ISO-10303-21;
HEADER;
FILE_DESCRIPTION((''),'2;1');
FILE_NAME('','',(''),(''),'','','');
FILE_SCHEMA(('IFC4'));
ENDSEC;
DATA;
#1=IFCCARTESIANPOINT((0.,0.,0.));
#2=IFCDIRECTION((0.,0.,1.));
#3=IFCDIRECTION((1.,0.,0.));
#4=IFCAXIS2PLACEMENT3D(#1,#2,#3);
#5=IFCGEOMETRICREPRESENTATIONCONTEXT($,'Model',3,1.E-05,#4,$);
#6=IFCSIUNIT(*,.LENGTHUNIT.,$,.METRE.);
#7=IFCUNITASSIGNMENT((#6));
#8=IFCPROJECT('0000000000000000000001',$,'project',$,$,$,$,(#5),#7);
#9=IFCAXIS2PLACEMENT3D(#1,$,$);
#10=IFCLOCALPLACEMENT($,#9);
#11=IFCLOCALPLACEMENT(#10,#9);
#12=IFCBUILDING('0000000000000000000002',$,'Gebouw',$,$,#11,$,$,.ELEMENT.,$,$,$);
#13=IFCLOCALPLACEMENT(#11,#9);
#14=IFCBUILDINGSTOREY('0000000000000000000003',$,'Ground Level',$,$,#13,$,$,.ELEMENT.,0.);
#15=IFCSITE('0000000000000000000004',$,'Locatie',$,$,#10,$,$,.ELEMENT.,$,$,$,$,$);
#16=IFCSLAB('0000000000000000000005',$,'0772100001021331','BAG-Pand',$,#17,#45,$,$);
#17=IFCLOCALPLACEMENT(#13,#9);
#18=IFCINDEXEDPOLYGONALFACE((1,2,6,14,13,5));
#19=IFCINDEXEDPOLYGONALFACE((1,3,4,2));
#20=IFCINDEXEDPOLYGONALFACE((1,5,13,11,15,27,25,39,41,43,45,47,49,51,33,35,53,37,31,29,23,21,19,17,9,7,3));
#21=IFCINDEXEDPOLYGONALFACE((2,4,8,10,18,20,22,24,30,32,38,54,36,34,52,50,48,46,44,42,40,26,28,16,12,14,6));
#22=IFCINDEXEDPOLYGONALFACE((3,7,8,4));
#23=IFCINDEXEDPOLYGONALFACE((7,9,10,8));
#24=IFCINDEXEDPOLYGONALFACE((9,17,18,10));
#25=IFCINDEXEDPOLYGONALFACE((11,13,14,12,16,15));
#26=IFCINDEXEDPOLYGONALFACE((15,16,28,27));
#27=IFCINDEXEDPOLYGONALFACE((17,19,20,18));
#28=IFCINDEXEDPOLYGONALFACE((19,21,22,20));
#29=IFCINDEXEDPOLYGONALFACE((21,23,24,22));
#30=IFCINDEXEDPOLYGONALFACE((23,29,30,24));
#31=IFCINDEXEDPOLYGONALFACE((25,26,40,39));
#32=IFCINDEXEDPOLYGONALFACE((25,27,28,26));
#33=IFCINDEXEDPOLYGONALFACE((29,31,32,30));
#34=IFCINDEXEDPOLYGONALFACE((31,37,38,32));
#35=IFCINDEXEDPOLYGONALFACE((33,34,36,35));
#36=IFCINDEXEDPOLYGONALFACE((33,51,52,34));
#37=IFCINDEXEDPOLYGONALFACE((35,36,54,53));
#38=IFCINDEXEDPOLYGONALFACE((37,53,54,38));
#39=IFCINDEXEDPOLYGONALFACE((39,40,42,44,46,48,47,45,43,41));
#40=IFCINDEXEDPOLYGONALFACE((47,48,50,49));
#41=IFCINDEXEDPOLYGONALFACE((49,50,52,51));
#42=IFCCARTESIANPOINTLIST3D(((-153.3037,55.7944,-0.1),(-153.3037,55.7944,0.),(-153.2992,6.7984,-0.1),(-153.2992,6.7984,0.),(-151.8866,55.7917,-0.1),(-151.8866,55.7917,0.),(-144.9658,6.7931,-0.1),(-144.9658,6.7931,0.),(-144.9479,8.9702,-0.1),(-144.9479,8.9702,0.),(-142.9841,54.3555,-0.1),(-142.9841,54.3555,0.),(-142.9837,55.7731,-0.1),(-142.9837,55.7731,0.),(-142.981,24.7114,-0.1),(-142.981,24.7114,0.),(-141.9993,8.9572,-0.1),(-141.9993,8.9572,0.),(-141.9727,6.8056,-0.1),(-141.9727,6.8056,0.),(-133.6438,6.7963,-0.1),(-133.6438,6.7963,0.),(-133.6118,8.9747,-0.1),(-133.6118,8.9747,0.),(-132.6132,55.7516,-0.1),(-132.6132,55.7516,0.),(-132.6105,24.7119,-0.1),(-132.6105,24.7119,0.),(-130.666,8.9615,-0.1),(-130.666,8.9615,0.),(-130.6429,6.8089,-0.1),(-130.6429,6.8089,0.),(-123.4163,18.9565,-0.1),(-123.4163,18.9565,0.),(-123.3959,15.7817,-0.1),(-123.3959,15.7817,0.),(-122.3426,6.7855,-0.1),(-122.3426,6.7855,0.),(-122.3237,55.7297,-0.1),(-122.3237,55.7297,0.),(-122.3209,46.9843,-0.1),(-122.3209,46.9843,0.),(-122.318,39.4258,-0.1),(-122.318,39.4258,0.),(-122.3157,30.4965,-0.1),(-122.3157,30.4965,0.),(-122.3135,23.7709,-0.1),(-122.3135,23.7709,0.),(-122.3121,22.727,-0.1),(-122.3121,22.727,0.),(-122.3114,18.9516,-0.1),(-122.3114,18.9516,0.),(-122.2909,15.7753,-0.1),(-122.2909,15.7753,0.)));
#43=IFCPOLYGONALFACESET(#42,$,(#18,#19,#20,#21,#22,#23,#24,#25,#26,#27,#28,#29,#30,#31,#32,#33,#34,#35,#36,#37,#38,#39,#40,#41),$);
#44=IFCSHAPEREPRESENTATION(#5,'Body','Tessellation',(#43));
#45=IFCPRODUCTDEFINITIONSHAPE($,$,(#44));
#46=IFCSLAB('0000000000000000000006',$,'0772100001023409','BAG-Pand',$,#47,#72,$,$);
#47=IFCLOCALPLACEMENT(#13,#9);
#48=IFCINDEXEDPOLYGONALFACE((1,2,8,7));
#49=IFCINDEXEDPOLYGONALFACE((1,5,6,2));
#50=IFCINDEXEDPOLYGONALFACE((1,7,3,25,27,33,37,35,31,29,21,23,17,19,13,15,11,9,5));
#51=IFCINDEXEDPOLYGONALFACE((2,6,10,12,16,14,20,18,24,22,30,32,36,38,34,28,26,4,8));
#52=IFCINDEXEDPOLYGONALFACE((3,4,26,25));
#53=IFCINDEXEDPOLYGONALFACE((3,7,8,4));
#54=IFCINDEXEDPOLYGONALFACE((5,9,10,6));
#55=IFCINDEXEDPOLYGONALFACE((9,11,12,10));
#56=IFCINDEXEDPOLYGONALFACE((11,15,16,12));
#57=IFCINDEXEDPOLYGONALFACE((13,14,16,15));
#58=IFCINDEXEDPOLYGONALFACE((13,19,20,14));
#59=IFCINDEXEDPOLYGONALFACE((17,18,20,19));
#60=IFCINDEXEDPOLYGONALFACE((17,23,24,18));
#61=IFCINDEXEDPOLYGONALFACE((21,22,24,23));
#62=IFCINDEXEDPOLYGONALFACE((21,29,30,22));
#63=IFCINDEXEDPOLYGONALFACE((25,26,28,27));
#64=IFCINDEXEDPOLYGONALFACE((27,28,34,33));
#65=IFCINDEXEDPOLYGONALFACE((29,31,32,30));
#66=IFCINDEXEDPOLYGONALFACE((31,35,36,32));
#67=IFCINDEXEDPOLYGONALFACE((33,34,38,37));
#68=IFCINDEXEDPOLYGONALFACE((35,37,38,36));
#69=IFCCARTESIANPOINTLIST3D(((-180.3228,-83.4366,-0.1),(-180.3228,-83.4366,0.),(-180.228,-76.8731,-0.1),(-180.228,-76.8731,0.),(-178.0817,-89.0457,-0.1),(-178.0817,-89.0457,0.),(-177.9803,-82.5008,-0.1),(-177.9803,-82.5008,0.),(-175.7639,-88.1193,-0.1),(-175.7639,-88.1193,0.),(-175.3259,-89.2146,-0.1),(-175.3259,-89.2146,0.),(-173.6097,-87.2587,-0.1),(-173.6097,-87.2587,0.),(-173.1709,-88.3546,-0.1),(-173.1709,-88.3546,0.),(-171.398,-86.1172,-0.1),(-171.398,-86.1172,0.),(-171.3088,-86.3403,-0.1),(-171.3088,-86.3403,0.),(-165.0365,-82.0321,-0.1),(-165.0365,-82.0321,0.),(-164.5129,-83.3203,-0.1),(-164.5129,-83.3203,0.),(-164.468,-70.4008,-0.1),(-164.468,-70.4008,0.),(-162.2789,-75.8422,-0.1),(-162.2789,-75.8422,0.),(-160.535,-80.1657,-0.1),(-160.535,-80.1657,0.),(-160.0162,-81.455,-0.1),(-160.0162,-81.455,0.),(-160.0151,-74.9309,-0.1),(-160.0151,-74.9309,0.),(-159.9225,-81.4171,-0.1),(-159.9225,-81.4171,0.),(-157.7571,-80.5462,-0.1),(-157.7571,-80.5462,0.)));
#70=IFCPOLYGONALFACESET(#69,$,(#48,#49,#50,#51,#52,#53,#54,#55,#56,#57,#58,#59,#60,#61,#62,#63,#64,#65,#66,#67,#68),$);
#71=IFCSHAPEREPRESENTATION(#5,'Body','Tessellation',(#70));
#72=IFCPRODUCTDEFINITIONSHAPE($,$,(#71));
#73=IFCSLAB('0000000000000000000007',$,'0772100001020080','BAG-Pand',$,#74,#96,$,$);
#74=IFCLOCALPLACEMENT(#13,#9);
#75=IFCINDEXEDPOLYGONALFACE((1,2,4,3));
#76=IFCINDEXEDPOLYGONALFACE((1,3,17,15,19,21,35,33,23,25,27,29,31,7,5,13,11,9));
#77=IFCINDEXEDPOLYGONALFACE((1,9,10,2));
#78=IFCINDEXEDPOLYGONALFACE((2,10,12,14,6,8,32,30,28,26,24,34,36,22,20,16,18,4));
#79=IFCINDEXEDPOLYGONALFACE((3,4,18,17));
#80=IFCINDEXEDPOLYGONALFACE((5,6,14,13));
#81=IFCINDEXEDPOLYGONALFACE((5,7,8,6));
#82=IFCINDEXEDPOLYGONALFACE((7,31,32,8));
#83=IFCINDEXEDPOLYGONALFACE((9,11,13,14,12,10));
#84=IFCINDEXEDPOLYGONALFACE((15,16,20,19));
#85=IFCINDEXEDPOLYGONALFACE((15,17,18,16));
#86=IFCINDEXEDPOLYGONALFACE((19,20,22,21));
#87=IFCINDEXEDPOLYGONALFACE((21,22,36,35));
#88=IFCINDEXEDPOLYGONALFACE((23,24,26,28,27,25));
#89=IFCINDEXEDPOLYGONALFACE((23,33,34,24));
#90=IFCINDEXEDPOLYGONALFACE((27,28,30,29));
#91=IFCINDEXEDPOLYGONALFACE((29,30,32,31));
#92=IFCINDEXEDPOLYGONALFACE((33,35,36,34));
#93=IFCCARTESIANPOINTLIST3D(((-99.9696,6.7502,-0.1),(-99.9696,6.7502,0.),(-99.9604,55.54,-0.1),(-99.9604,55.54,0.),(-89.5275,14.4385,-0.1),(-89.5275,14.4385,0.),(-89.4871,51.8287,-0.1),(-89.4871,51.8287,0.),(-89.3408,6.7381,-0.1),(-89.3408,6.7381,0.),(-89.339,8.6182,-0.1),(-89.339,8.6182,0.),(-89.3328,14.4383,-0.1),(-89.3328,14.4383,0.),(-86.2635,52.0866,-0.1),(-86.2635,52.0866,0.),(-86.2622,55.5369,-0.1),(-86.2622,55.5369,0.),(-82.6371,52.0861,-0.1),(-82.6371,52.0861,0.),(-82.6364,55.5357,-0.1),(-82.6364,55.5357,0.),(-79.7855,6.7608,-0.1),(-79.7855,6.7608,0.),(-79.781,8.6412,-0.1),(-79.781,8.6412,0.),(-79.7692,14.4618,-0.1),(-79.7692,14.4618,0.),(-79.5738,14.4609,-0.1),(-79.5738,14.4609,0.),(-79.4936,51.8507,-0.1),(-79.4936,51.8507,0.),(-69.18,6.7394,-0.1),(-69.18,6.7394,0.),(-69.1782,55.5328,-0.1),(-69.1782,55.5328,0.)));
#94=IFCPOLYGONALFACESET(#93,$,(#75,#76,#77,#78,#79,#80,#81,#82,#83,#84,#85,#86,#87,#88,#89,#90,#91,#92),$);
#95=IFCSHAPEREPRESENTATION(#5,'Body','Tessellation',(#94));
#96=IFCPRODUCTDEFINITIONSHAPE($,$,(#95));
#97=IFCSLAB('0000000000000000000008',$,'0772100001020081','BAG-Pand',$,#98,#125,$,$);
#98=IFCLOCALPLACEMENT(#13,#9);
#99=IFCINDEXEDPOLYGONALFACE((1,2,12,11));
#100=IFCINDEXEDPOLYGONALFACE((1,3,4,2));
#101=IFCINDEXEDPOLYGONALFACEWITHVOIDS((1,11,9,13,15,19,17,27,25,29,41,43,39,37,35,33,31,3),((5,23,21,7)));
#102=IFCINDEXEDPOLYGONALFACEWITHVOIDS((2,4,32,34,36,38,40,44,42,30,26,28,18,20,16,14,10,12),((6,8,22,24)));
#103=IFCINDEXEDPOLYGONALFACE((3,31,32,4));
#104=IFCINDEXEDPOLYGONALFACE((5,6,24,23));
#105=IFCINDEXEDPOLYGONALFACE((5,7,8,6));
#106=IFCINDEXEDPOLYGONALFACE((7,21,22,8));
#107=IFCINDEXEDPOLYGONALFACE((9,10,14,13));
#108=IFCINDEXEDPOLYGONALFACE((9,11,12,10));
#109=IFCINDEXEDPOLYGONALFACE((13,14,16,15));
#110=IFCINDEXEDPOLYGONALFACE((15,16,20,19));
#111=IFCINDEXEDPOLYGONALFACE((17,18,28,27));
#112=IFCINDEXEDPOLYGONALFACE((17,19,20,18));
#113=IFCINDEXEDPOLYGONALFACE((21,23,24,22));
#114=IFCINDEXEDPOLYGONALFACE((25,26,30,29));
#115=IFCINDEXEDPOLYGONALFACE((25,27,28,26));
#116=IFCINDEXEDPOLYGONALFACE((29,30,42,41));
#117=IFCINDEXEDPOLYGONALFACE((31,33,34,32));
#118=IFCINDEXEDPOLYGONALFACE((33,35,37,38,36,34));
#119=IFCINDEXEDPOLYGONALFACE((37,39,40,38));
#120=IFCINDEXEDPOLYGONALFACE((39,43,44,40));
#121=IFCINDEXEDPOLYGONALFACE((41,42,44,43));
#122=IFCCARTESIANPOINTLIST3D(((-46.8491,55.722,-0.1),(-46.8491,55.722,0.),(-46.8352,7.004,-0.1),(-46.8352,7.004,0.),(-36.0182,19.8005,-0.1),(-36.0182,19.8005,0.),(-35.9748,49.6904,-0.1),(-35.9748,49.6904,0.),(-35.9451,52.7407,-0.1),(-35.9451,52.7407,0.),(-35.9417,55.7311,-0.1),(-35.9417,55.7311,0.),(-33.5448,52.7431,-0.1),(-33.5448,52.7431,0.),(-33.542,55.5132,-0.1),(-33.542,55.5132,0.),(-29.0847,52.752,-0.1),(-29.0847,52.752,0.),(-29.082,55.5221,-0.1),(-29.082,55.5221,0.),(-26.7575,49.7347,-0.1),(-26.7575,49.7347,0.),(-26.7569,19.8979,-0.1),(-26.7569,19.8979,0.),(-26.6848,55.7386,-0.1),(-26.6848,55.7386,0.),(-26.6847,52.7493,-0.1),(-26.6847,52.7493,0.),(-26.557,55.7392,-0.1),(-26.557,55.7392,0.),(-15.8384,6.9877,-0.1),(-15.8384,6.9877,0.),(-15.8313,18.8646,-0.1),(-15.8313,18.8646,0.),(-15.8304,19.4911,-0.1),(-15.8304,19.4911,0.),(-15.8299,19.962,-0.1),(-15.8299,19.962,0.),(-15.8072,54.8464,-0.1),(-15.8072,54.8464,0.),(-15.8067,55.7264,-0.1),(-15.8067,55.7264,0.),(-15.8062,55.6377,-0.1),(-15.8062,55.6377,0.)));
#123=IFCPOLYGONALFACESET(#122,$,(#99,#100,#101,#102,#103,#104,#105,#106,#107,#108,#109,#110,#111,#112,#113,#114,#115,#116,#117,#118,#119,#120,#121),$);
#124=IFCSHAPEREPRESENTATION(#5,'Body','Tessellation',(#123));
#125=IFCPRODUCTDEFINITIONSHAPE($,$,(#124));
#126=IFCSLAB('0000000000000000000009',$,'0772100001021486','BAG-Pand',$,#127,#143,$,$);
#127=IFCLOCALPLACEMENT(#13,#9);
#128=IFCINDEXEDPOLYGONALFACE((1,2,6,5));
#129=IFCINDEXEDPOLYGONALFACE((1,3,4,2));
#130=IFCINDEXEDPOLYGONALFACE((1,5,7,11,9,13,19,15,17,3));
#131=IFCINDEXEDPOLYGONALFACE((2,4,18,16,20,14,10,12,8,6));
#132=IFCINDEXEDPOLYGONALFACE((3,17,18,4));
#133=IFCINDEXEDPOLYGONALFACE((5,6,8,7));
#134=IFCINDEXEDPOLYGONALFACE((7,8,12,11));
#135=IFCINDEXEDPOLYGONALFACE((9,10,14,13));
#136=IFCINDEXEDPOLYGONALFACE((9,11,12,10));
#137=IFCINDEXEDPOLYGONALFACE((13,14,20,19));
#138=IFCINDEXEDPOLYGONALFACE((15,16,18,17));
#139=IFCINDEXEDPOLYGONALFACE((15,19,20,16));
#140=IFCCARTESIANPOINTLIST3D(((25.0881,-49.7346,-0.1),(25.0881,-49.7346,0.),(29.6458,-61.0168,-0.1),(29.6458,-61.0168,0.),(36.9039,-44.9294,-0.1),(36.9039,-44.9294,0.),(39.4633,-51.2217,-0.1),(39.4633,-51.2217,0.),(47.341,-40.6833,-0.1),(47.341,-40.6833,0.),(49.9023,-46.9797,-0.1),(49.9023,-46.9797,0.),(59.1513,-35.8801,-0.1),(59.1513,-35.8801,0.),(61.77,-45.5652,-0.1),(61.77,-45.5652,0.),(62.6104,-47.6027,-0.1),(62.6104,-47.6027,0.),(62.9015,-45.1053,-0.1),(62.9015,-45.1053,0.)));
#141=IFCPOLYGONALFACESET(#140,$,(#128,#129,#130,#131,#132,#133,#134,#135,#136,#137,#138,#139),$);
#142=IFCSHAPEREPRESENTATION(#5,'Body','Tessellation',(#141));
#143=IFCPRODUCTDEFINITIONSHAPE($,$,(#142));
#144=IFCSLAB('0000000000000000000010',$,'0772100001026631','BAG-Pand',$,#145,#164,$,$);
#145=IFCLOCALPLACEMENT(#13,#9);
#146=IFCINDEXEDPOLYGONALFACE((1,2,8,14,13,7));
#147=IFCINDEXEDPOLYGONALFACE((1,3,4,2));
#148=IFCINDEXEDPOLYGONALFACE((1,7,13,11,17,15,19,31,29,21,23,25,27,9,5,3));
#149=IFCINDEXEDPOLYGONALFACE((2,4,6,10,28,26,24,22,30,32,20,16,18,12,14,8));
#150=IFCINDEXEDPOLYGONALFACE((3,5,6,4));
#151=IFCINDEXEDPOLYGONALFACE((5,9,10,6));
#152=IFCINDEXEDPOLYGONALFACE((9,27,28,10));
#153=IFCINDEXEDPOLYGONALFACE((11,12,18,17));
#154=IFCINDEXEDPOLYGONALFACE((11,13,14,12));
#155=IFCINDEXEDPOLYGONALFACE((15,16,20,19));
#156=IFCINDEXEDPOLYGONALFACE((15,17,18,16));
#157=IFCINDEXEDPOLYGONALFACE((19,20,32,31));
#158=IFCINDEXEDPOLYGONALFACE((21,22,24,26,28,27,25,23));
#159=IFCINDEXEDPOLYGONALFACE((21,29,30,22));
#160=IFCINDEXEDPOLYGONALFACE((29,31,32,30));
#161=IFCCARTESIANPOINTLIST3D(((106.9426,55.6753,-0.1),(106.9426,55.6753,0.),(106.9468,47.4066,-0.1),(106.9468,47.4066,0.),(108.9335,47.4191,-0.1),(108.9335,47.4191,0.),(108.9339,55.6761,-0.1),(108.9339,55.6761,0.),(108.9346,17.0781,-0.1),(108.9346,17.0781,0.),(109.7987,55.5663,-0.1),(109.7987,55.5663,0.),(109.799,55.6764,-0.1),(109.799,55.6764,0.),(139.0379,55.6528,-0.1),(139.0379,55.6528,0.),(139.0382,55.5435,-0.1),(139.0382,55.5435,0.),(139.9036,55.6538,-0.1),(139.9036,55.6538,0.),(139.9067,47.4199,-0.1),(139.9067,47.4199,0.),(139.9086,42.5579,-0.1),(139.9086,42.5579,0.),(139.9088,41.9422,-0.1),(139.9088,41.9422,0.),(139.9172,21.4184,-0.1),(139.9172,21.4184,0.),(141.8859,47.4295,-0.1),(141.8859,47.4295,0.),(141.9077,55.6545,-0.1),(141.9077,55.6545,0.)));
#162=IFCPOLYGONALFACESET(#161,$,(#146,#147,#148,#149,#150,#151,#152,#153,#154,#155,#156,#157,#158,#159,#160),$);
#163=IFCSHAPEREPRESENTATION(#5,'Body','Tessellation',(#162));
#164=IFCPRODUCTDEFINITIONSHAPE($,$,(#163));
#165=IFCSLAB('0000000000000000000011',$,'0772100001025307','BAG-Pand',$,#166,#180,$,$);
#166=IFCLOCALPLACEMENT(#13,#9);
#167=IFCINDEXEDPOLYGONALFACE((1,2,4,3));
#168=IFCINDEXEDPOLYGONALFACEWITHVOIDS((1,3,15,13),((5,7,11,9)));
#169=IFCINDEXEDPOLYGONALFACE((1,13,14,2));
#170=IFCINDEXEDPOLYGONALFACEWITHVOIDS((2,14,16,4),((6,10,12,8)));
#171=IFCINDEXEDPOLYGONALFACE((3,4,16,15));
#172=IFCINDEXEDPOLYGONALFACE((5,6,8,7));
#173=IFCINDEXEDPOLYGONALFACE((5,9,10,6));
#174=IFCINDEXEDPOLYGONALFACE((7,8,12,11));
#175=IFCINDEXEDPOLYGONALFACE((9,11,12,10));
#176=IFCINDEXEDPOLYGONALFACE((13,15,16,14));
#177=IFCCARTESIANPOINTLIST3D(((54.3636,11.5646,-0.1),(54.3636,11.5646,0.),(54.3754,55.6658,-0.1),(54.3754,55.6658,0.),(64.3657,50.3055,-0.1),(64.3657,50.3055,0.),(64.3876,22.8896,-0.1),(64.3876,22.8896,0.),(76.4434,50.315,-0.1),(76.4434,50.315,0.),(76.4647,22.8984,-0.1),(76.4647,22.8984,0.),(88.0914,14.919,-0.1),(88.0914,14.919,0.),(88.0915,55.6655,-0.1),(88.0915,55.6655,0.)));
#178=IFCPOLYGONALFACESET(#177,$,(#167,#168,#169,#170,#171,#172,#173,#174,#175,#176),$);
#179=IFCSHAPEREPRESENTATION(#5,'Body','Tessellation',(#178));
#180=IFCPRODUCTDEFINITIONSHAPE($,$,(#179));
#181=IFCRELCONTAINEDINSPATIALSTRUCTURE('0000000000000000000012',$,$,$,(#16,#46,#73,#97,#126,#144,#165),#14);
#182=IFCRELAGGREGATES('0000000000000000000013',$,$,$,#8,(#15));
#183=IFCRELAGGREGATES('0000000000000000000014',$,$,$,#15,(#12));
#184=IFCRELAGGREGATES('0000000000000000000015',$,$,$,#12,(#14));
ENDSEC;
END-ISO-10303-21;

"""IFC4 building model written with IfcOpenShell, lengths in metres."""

from ifc_helpers import new_model, si_unit, frame, origin, origin_with_axes, place, context, project, spatial, polyline, outline, extrude, element, save


model = new_model("IFC4")

# Units and contexts
model_context = context("Model", 3, precision=1e-05, world=origin_with_axes())
ifc_project = project(units=[si_unit("LENGTHUNIT", "METRE")], contexts=[model_context])

# Site, building, storey
site_placement = place(None, origin())
site = spatial("IfcSite", under=ifc_project, at=site_placement, Name="Locatie", CompositionType="ELEMENT")
building_placement = place(site_placement, origin())
building = spatial("IfcBuilding", under=site, at=building_placement, Name="Gebouw", CompositionType="ELEMENT")
storey_placement = place(building_placement, origin())
storey = spatial("IfcBuildingStorey", under=building, at=storey_placement, Name="Ground Level", CompositionType="ELEMENT", Elevation=0.0)

# Slabs
slab_1_placement = place(storey_placement, origin())
element("IfcSlab", 1, at=slab_1_placement, inside=storey, Name="0772100001021331", Description="BAG-Pand", context=model_context, shape_type="SweptSolid", body=[
    extrude(outline(polyline([(-153.3037, 55.7944), (-151.8866, 55.7917), (-142.9837, 55.7731), (-142.9841, 54.3555), (-142.981, 24.7114), (-132.6105, 24.7119), (-132.6132, 55.7516), (-122.3237, 55.7297), (-122.3209, 46.9843), (-122.318, 39.4258), (-122.3157, 30.4965), (-122.3135, 23.7709), (-122.3121, 22.727), (-122.3114, 18.9516), (-123.4163, 18.9565), (-123.3959, 15.7817), (-122.2909, 15.7753), (-122.3426, 6.7855), (-130.6429, 6.8089), (-130.666, 8.9615), (-133.6118, 8.9747), (-133.6438, 6.7963), (-141.9727, 6.8056), (-141.9993, 8.9572), (-144.9479, 8.9702), (-144.9658, 6.7931), (-153.2992, 6.7984), (-153.3037, 55.7944)])), frame((0.0, 0.0, -0.1), z_axis=(0.0, 0.0, 1.0), x_axis=(1.0, 0.0, 0.0)), (0.0, 0.0, 1.0), 0.1),
])
slab_2_placement = place(storey_placement, origin())
element("IfcSlab", 2, at=slab_2_placement, inside=storey, Name="0772100001023409", Description="BAG-Pand", context=model_context, shape_type="SweptSolid", body=[
    extrude(outline(polyline([(-180.3228, -83.4366), (-177.9803, -82.5008), (-180.228, -76.8731), (-164.468, -70.4008), (-162.2789, -75.8422), (-160.0151, -74.9309), (-157.7571, -80.5462), (-159.9225, -81.4171), (-160.0162, -81.455), (-160.535, -80.1657), (-165.0365, -82.0321), (-164.5129, -83.3203), (-171.398, -86.1172), (-171.3088, -86.3403), (-173.6097, -87.2587), (-173.1709, -88.3546), (-175.3259, -89.2146), (-175.7639, -88.1193), (-178.0817, -89.0457), (-180.3228, -83.4366)])), frame((0.0, 0.0, -0.1), z_axis=(0.0, 0.0, 1.0), x_axis=(1.0, 0.0, 0.0)), (0.0, 0.0, 1.0), 0.1),
])
slab_3_placement = place(storey_placement, origin())
element("IfcSlab", 3, at=slab_3_placement, inside=storey, Name="0772100001020080", Description="BAG-Pand", context=model_context, shape_type="SweptSolid", body=[
    extrude(outline(polyline([(-82.6364, 55.5357), (-69.1782, 55.5328), (-69.18, 6.7394), (-79.7855, 6.7608), (-79.781, 8.6412), (-79.7692, 14.4618), (-79.5738, 14.4609), (-79.4936, 51.8507), (-89.4871, 51.8287), (-89.5275, 14.4385), (-89.3328, 14.4383), (-89.339, 8.6182), (-89.3408, 6.7381), (-99.9696, 6.7502), (-99.9604, 55.54), (-86.2622, 55.5369), (-86.2635, 52.0866), (-82.6371, 52.0861), (-82.6364, 55.5357)])), frame((0.0, 0.0, -0.1), z_axis=(0.0, 0.0, 1.0), x_axis=(1.0, 0.0, 0.0)), (0.0, 0.0, 1.0), 0.1),
])
slab_4_placement = place(storey_placement, origin())
element("IfcSlab", 4, at=slab_4_placement, inside=storey, Name="0772100001020081", Description="BAG-Pand", context=model_context, shape_type="SweptSolid", body=[
    extrude(outline(polyline([(-46.8491, 55.722), (-35.9417, 55.7311), (-35.9451, 52.7407), (-33.5448, 52.7431), (-33.542, 55.5132), (-29.082, 55.5221), (-29.0847, 52.752), (-26.6847, 52.7493), (-26.6848, 55.7386), (-26.557, 55.7392), (-15.8067, 55.7264), (-15.8062, 55.6377), (-15.8072, 54.8464), (-15.8299, 19.962), (-15.8304, 19.4911), (-15.8313, 18.8646), (-15.8384, 6.9877), (-46.8352, 7.004), (-46.8491, 55.722)]), holes=[polyline([(-26.7569, 19.8979), (-26.7575, 49.7347), (-35.9748, 49.6904), (-36.0182, 19.8005), (-26.7569, 19.8979)])]), frame((0.0, 0.0, -0.1), z_axis=(0.0, 0.0, 1.0), x_axis=(1.0, 0.0, 0.0)), (0.0, 0.0, 1.0), 0.1),
])
slab_5_placement = place(storey_placement, origin())
element("IfcSlab", 5, at=slab_5_placement, inside=storey, Name="0772100001021486", Description="BAG-Pand", context=model_context, shape_type="SweptSolid", body=[
    extrude(outline(polyline([(25.0881, -49.7346), (36.9039, -44.9294), (39.4633, -51.2217), (49.9023, -46.9797), (47.341, -40.6833), (59.1513, -35.8801), (62.9015, -45.1053), (61.77, -45.5652), (62.6104, -47.6027), (29.6458, -61.0168), (25.0881, -49.7346)])), frame((0.0, 0.0, -0.1), z_axis=(0.0, 0.0, 1.0), x_axis=(1.0, 0.0, 0.0)), (0.0, 0.0, 1.0), 0.1),
])
slab_6_placement = place(storey_placement, origin())
element("IfcSlab", 6, at=slab_6_placement, inside=storey, Name="0772100001026631", Description="BAG-Pand", context=model_context, shape_type="SweptSolid", body=[
    extrude(outline(polyline([(108.9335, 47.4191), (106.9468, 47.4066), (106.9426, 55.6753), (108.9339, 55.6761), (109.799, 55.6764), (109.7987, 55.5663), (139.0382, 55.5435), (139.0379, 55.6528), (139.9036, 55.6538), (141.9077, 55.6545), (141.8859, 47.4295), (139.9067, 47.4199), (139.9086, 42.5579), (139.9088, 41.9422), (139.9172, 21.4184), (108.9346, 17.0781), (108.9335, 47.4191)])), frame((0.0, 0.0, -0.1), z_axis=(0.0, 0.0, 1.0), x_axis=(1.0, 0.0, 0.0)), (0.0, 0.0, 1.0), 0.1),
])
slab_7_placement = place(storey_placement, origin())
element("IfcSlab", 7, at=slab_7_placement, inside=storey, Name="0772100001025307", Description="BAG-Pand", context=model_context, shape_type="SweptSolid", body=[
    extrude(outline(polyline([(54.3754, 55.6658), (88.0915, 55.6655), (88.0914, 14.919), (54.3636, 11.5646), (54.3754, 55.6658)]), holes=[polyline([(76.4647, 22.8984), (76.4434, 50.315), (64.3657, 50.3055), (64.3876, 22.8896), (76.4647, 22.8984)])]), frame((0.0, 0.0, -0.1), z_axis=(0.0, 0.0, 1.0), x_axis=(1.0, 0.0, 0.0)), (0.0, 0.0, 1.0), 0.1),
])

save(model, "model.ifc")
